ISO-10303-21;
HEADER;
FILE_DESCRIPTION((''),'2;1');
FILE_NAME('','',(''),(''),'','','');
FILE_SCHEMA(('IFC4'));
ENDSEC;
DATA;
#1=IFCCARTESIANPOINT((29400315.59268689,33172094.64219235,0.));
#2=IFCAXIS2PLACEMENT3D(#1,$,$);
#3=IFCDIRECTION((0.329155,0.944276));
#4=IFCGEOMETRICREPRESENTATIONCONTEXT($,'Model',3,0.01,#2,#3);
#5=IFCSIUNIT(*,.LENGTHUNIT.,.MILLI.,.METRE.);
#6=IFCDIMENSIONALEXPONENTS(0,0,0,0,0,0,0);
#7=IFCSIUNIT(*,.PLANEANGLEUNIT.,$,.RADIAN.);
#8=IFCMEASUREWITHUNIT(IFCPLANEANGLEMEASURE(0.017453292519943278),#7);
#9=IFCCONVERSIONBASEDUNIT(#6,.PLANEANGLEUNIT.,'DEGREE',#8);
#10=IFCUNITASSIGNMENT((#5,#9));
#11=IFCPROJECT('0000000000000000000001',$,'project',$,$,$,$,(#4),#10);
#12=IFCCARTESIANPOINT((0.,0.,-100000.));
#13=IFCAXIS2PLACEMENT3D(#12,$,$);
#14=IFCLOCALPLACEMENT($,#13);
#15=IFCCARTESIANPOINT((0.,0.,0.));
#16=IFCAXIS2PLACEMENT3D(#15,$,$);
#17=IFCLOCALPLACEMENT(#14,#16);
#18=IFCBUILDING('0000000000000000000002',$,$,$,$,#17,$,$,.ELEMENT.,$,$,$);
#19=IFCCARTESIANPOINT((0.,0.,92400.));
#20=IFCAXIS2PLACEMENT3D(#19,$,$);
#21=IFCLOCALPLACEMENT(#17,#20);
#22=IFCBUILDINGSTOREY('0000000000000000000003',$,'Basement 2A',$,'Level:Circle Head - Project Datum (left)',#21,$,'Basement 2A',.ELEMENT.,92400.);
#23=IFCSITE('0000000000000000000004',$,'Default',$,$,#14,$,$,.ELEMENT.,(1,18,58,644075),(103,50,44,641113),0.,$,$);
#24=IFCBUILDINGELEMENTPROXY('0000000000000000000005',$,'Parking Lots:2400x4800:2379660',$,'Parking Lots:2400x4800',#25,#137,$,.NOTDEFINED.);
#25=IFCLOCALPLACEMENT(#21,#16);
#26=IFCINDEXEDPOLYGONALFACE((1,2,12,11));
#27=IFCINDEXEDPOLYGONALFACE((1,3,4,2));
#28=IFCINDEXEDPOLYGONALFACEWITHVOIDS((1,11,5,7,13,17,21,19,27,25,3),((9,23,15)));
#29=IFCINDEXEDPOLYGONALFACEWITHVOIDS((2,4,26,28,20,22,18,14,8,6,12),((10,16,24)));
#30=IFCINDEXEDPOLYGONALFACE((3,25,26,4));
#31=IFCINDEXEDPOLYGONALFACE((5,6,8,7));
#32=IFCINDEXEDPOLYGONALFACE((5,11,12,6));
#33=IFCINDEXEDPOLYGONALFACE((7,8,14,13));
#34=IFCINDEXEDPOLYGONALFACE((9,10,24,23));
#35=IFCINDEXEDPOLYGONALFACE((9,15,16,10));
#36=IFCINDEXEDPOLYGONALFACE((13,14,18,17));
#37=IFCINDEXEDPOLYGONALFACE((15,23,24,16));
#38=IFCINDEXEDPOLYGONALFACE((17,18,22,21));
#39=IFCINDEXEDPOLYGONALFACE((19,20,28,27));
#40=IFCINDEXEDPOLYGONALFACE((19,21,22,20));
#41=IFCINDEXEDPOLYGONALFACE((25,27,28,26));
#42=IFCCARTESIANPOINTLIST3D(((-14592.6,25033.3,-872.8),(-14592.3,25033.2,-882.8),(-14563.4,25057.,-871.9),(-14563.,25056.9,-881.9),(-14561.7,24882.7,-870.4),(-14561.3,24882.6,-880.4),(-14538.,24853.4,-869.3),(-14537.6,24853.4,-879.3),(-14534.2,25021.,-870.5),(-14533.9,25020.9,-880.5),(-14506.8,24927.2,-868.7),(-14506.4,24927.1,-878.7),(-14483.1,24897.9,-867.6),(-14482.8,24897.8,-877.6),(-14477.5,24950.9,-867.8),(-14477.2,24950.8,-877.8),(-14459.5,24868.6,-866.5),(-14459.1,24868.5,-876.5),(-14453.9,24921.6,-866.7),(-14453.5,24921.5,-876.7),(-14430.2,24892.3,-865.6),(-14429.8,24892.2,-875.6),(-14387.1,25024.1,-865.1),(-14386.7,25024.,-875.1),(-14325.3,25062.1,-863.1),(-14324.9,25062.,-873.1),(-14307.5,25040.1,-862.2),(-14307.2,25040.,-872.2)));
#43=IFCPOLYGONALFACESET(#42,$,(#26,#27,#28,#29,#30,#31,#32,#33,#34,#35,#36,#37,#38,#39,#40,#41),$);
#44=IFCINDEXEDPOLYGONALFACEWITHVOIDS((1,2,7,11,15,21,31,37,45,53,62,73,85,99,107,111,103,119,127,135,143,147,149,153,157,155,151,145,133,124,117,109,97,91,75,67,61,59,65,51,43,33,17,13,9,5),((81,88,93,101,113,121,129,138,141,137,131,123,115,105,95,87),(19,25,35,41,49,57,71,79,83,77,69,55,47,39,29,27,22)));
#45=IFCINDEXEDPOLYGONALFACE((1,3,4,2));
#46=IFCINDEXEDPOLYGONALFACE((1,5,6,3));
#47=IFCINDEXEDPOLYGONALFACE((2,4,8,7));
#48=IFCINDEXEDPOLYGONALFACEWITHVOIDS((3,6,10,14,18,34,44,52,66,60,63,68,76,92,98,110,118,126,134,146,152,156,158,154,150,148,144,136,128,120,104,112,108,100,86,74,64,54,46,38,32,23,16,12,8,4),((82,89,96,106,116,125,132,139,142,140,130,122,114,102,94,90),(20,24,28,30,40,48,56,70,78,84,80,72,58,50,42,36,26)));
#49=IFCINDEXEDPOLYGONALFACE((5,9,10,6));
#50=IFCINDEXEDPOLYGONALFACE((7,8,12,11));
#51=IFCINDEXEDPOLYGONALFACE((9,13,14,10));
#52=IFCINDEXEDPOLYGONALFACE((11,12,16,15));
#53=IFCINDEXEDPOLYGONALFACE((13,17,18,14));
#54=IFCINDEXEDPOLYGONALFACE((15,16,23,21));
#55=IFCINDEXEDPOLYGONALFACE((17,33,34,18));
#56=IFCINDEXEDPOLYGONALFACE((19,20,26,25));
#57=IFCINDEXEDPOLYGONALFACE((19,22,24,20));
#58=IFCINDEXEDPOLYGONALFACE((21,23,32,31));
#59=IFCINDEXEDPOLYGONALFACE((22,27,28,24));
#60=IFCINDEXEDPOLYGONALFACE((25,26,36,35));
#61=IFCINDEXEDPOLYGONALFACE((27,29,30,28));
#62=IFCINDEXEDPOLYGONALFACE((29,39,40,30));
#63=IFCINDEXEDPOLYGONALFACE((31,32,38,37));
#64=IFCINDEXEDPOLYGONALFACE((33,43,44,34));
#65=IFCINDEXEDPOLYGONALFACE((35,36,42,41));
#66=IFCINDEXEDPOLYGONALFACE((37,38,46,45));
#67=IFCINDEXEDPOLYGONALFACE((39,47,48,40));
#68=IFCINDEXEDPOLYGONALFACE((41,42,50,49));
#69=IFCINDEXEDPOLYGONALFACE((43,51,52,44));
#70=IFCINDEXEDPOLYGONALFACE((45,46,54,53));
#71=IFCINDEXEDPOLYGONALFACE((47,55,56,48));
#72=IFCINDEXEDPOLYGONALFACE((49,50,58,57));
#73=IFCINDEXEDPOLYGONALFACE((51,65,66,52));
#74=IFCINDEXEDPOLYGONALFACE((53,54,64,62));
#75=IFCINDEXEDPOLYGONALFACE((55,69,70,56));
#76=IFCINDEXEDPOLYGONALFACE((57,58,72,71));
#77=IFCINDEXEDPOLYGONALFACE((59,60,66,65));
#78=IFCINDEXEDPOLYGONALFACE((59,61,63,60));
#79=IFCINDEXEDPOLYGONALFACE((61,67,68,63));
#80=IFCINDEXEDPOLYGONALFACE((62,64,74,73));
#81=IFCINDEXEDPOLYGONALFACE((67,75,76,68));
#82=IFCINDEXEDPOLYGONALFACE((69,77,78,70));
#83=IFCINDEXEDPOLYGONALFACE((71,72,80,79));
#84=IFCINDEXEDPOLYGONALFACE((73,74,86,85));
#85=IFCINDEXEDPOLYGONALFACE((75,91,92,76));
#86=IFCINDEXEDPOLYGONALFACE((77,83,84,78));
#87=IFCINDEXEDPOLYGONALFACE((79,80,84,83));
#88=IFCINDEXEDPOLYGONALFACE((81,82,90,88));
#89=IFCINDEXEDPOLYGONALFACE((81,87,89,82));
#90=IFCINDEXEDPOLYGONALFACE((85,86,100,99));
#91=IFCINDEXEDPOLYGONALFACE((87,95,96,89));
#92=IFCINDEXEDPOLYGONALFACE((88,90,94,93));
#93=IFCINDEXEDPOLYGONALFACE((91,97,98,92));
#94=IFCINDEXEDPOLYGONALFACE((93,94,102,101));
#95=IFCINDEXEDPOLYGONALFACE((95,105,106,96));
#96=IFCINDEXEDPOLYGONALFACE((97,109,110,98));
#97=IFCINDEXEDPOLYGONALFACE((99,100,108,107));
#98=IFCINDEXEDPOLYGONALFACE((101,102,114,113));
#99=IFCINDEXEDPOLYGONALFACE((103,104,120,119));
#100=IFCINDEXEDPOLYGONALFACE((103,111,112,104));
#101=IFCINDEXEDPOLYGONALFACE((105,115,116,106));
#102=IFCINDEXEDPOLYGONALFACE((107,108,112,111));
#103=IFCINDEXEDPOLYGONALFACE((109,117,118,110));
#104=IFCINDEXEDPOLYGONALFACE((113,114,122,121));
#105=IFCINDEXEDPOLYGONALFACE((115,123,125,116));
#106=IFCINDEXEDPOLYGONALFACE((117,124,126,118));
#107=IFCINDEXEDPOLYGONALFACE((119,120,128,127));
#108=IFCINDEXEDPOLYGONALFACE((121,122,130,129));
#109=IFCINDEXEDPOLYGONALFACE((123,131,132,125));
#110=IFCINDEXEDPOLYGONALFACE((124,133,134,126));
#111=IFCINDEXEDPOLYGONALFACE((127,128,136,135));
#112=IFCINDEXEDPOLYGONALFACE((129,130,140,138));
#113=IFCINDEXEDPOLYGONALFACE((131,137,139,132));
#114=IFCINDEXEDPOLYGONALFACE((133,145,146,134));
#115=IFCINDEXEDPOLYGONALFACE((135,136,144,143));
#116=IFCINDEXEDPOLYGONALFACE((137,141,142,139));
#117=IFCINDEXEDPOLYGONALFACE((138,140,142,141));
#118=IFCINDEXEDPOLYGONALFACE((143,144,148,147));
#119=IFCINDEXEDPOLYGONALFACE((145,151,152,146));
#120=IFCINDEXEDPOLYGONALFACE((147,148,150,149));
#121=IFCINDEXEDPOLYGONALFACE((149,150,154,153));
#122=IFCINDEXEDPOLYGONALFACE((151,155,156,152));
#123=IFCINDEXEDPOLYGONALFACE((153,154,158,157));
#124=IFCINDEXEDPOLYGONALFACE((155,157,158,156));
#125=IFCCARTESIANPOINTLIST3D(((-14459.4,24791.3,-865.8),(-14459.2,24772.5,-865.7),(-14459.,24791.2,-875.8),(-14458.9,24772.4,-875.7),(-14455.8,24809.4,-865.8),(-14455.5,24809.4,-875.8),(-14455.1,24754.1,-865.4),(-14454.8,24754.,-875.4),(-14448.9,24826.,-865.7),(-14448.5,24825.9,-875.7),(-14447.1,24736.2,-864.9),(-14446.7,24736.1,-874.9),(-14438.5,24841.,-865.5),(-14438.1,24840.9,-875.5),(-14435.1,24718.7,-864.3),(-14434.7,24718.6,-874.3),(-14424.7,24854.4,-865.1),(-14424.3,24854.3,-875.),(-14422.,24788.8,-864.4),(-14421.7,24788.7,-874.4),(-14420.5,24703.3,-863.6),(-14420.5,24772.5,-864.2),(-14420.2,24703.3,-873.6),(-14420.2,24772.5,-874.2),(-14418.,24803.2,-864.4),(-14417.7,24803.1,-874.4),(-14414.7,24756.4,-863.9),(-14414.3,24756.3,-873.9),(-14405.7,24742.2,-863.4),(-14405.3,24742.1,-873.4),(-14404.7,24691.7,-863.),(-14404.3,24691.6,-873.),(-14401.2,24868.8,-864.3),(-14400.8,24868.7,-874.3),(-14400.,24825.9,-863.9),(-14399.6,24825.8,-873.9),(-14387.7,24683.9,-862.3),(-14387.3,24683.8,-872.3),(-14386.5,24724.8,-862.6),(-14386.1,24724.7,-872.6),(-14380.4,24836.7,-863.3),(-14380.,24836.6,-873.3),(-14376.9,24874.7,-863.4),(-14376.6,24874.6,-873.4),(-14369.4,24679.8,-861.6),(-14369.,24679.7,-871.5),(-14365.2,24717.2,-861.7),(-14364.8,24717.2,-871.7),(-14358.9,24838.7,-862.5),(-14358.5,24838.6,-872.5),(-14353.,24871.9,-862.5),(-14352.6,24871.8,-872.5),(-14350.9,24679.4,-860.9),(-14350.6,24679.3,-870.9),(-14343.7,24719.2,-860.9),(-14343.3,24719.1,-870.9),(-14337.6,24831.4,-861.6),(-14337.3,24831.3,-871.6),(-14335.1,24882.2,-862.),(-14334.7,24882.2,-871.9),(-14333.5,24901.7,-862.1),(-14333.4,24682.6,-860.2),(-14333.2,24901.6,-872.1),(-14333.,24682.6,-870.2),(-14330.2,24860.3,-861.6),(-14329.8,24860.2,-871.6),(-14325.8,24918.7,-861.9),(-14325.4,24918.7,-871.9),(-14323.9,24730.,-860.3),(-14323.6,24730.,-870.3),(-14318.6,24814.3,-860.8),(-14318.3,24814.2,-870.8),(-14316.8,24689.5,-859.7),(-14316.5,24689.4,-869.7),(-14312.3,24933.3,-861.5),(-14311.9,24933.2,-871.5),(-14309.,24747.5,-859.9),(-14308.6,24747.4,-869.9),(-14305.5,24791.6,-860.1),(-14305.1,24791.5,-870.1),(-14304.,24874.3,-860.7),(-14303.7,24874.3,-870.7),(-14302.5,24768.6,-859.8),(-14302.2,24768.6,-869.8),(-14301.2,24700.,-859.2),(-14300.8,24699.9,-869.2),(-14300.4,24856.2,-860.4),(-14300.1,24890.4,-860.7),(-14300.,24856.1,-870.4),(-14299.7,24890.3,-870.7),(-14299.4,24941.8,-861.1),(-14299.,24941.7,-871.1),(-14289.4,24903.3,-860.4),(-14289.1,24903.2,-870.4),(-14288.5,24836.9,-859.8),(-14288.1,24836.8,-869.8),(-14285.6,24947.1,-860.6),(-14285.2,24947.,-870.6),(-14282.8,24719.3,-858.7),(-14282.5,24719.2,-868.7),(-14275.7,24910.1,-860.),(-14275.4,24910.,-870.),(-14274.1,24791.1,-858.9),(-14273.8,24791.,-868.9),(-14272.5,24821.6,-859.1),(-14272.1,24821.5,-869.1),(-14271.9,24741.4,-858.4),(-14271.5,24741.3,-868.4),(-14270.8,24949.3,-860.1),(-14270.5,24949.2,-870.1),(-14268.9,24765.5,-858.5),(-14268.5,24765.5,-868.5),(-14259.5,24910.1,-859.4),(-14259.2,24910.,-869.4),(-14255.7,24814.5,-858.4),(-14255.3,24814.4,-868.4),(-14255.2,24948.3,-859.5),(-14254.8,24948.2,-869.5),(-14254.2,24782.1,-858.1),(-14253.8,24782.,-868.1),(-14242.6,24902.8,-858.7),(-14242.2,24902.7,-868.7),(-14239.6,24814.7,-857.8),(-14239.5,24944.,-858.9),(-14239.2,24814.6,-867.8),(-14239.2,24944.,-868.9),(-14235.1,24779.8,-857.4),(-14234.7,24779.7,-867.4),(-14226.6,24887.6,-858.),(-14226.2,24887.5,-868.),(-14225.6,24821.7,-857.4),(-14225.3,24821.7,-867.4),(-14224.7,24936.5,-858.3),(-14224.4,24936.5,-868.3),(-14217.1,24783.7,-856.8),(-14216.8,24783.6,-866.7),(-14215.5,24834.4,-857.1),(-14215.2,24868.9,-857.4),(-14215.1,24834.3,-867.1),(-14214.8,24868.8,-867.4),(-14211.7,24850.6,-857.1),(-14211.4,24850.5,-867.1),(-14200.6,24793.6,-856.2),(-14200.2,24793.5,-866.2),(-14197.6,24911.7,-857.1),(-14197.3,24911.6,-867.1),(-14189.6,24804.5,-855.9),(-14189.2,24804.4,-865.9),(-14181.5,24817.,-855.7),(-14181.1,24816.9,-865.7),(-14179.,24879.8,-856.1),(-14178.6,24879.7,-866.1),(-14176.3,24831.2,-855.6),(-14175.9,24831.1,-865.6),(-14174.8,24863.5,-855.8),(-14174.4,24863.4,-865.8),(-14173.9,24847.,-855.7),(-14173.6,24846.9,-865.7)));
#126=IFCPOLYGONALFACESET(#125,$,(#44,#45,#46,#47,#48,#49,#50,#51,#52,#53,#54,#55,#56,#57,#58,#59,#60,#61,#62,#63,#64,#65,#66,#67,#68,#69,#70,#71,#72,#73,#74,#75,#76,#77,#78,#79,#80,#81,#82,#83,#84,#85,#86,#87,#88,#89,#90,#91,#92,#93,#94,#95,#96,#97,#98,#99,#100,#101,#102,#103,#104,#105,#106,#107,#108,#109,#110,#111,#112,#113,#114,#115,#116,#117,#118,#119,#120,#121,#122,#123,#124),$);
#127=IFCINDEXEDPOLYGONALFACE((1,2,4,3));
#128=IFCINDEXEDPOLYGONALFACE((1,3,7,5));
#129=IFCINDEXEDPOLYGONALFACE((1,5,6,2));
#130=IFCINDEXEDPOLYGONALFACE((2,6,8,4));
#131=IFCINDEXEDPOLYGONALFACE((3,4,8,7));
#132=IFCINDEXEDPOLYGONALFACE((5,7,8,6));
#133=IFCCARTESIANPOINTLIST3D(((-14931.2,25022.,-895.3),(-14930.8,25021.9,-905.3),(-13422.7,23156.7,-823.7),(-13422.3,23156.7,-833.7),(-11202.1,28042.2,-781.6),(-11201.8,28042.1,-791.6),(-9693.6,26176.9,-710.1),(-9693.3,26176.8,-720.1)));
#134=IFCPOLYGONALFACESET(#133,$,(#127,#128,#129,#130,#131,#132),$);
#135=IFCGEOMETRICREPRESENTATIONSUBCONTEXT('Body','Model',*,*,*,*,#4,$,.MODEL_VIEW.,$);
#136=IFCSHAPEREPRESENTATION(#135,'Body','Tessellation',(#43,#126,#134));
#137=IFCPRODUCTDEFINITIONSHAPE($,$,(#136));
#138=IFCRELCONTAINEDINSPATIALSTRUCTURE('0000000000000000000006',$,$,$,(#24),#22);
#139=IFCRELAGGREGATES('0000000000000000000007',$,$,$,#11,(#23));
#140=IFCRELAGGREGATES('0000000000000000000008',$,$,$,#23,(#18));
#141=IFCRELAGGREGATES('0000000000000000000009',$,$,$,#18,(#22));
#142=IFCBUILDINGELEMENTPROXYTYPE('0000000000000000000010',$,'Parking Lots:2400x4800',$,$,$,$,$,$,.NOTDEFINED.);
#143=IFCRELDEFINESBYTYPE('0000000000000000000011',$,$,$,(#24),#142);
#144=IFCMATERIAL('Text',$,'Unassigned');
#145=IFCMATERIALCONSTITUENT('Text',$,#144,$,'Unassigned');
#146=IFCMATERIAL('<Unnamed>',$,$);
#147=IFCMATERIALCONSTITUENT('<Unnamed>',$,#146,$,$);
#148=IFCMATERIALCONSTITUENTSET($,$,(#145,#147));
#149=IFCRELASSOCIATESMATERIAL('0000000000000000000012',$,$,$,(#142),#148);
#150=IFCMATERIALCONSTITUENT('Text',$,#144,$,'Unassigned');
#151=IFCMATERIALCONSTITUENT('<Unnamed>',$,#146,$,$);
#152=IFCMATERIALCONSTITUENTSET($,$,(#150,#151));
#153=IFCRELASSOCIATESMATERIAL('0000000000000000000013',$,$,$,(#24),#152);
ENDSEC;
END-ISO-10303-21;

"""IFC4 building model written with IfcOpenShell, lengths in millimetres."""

from ifc_helpers import new_model, entity, si_unit, converted_unit, direction, frame, origin, place, context, subcontext, project, spatial, indexed_curve, outline, extrude, source, transform, mapped, material, constituent, constituent_set, type_object, type_shapes, element, save


model = new_model("IFC4")

# Units and contexts
model_context = context("Model", 3, precision=0.01, world=frame((29400315.59268689, 33172094.64219235, 0.0)), true_north=direction((0.329155, 0.944276)))
body_context = subcontext(model_context, "Body", "Model", "MODEL_VIEW")
ifc_project = project(units=[si_unit("LENGTHUNIT", "METRE", prefix="MILLI"), converted_unit("PLANEANGLEUNIT", "DEGREE", entity("IfcPlaneAngleMeasure", 0.017453292519943278), si_unit("PLANEANGLEUNIT", "RADIAN"), dimensions=[0, 0, 0, 0, 0, 0, 0])], contexts=[model_context])

# Site, building, storey
site_placement = place(None, frame((0.0, 0.0, -100000.0)))
site = spatial("IfcSite", under=ifc_project, at=site_placement, Name="Default", CompositionType="ELEMENT", RefLatitude=(1, 18, 58, 644075), RefLongitude=(103, 50, 44, 641113), RefElevation=0.0)
building_placement = place(site_placement, origin())
building = spatial("IfcBuilding", under=site, at=building_placement, CompositionType="ELEMENT")
storey_placement = place(building_placement, frame((0.0, 0.0, 92400.0)))
storey = spatial("IfcBuildingStorey", under=building, at=storey_placement, Name="Basement 2A", ObjectType="Level:Circle Head - Project Datum (left)", LongName="Basement 2A", CompositionType="ELEMENT", Elevation=92400.0)

# Building element proxy
ifc_material_1 = material(Name="Text", Category="Unassigned")
ifc_material_2 = material(Name="<Unnamed>")
ifc_constituent_1 = constituent(ifc_material_1, Name="Text", Category="Unassigned")
ifc_constituent_2 = constituent(ifc_material_2, Name="<Unnamed>")
ifc_constituent_set_1 = constituent_set(constituents=[ifc_constituent_1, ifc_constituent_2])
ifc_constituent_3 = constituent(ifc_material_1, Name="Text", Category="Unassigned")
ifc_constituent_4 = constituent(ifc_material_2, Name="<Unnamed>")
ifc_constituent_set_2 = constituent_set(constituents=[ifc_constituent_3, ifc_constituent_4])
building_element_proxy_type_1 = type_object("IfcBuildingElementProxyType", Name="Parking Lots:2400x4800", PredefinedType="NOTDEFINED", material=ifc_constituent_set_2)
shared_shape_1 = source(origin(), body_context, "Body", "SweptSolid", [
    extrude(outline(indexed_curve([(-3.4, -109.2), (34.2, -109.2), (34.2, -38.5), (71.9, -38.5), (71.9, -0.9), (34.2, -0.9), (34.2, 187.5), (6.0, 187.5), (-140.0, -0.9), (-140.0, -38.5), (-3.4, -38.5), (-3.4, -109.2)], self_intersect=False), holes=[indexed_curve([(-3.4, -0.9), (-93.6, -0.9), (-3.4, 115.5), (-3.4, -0.9)], self_intersect=False)]), frame((344.7, -4490.8, 10.0)), (0.0, 0.0, 1.0), 10.0),
    extrude(outline(indexed_curve([(33.1, -33.7), (58.7, -33.7), (81.4, -25.4), (100.4, -9.3), (114.8, 14.2), (121.1, 32.4), (123.6, 50.4), (122.4, 68.4), (117.3, 86.2), (108.7, 102.9), (96.8, 117.4), (81.5, 129.8), (62.9, 140.0), (43.0, 147.1), (23.6, 150.4), (4.8, 149.7), (-13.3, 145.1), (-30.0, 137.1), (-44.2, 126.3), (-55.9, 112.7), (-65.1, 96.3), (-72.8, 70.8), (-72.6, 46.2), (-64.4, 23.2), (-48.2, 2.8), (-70.0, 1.8), (-88.2, -4.8), (-102.4, -16.4), (-112.7, -32.6), (-117.6, -47.3), (-119.2, -62.1), (-117.5, -77.1), (-112.5, -92.3), (-104.3, -106.7), (-93.2, -119.3), (-62.1, -139.4), (-26.7, -149.3), (-10.1, -149.3), (5.8, -146.0), (20.3, -139.9), (32.4, -131.3), (42.4, -120.3), (50.0, -106.9), (55.6, -87.8), (54.8, -69.1), (47.4, -51.1), (33.1, -33.7)], self_intersect=False), holes=[indexed_curve([(16.1, -90.5), (6.9, -102.7), (-7.5, -110.0), (-26.0, -111.2), (-47.1, -104.8), (-65.7, -93.2), (-77.1, -78.5), (-81.0, -62.3), (-77.7, -46.5), (-68.4, -33.9), (-54.1, -26.4), (-35.9, -25.2), (-14.7, -31.6), (4.7, -43.5), (16.1, -58.0), (19.8, -74.1), (16.1, -90.5)], self_intersect=False), indexed_curve([(79.9, 28.5), (67.3, 10.0), (49.0, -1.4), (26.7, -4.6), (2.0, 2.2), (-20.0, 16.5), (-32.9, 35.6), (-36.7, 57.4), (-31.3, 79.7), (-18.5, 98.3), (-0.2, 109.8), (22.2, 112.7), (47.2, 105.8), (61.7, 97.2), (74.2, 85.4), (82.9, 71.6), (85.8, 56.9), (79.9, 28.5)], self_intersect=False)]), frame((548.5, -4451.2, 10.0), z_axis=(0.0, 0.0, 1.0), x_axis=(-0.912083, -0.410006, 0.0)), (0.0, 0.0, 1.0), 10.0),
    extrude(outline(indexed_curve([(-1200.0, -2400.0), (1200.0, -2400.0), (1200.0, 2400.0), (-1200.0, 2400.0), (-1200.0, -2400.0)], self_intersect=False)), frame((1200.0, -2400.0, 0.0), z_axis=(0.0, 0.0, 1.0), x_axis=(-1.0, 0.0, 0.0)), (0.0, 0.0, 1.0), 10.0),
])
type_shapes(building_element_proxy_type_1, [shared_shape_1])
proxy_1_placement = place(storey_placement, frame((-11201.8, 28042.1, -791.6), z_axis=(-0.037166, 0.008281, 0.999275), x_axis=(0.628546, -0.7772, 0.029818)))
element("IfcBuildingElementProxy", 1, at=proxy_1_placement, inside=storey, type_object=building_element_proxy_type_1, material=ifc_constituent_set_1, Name="Parking Lots:2400x4800:2379660", ObjectType="Parking Lots:2400x4800", PredefinedType="NOTDEFINED", context=body_context, shape_type="MappedRepresentation", body=[
    mapped(shared_shape_1, transform((0.0, 0.0, 0.0), scale=1.0)),
])

save(model, "model.ifc")
